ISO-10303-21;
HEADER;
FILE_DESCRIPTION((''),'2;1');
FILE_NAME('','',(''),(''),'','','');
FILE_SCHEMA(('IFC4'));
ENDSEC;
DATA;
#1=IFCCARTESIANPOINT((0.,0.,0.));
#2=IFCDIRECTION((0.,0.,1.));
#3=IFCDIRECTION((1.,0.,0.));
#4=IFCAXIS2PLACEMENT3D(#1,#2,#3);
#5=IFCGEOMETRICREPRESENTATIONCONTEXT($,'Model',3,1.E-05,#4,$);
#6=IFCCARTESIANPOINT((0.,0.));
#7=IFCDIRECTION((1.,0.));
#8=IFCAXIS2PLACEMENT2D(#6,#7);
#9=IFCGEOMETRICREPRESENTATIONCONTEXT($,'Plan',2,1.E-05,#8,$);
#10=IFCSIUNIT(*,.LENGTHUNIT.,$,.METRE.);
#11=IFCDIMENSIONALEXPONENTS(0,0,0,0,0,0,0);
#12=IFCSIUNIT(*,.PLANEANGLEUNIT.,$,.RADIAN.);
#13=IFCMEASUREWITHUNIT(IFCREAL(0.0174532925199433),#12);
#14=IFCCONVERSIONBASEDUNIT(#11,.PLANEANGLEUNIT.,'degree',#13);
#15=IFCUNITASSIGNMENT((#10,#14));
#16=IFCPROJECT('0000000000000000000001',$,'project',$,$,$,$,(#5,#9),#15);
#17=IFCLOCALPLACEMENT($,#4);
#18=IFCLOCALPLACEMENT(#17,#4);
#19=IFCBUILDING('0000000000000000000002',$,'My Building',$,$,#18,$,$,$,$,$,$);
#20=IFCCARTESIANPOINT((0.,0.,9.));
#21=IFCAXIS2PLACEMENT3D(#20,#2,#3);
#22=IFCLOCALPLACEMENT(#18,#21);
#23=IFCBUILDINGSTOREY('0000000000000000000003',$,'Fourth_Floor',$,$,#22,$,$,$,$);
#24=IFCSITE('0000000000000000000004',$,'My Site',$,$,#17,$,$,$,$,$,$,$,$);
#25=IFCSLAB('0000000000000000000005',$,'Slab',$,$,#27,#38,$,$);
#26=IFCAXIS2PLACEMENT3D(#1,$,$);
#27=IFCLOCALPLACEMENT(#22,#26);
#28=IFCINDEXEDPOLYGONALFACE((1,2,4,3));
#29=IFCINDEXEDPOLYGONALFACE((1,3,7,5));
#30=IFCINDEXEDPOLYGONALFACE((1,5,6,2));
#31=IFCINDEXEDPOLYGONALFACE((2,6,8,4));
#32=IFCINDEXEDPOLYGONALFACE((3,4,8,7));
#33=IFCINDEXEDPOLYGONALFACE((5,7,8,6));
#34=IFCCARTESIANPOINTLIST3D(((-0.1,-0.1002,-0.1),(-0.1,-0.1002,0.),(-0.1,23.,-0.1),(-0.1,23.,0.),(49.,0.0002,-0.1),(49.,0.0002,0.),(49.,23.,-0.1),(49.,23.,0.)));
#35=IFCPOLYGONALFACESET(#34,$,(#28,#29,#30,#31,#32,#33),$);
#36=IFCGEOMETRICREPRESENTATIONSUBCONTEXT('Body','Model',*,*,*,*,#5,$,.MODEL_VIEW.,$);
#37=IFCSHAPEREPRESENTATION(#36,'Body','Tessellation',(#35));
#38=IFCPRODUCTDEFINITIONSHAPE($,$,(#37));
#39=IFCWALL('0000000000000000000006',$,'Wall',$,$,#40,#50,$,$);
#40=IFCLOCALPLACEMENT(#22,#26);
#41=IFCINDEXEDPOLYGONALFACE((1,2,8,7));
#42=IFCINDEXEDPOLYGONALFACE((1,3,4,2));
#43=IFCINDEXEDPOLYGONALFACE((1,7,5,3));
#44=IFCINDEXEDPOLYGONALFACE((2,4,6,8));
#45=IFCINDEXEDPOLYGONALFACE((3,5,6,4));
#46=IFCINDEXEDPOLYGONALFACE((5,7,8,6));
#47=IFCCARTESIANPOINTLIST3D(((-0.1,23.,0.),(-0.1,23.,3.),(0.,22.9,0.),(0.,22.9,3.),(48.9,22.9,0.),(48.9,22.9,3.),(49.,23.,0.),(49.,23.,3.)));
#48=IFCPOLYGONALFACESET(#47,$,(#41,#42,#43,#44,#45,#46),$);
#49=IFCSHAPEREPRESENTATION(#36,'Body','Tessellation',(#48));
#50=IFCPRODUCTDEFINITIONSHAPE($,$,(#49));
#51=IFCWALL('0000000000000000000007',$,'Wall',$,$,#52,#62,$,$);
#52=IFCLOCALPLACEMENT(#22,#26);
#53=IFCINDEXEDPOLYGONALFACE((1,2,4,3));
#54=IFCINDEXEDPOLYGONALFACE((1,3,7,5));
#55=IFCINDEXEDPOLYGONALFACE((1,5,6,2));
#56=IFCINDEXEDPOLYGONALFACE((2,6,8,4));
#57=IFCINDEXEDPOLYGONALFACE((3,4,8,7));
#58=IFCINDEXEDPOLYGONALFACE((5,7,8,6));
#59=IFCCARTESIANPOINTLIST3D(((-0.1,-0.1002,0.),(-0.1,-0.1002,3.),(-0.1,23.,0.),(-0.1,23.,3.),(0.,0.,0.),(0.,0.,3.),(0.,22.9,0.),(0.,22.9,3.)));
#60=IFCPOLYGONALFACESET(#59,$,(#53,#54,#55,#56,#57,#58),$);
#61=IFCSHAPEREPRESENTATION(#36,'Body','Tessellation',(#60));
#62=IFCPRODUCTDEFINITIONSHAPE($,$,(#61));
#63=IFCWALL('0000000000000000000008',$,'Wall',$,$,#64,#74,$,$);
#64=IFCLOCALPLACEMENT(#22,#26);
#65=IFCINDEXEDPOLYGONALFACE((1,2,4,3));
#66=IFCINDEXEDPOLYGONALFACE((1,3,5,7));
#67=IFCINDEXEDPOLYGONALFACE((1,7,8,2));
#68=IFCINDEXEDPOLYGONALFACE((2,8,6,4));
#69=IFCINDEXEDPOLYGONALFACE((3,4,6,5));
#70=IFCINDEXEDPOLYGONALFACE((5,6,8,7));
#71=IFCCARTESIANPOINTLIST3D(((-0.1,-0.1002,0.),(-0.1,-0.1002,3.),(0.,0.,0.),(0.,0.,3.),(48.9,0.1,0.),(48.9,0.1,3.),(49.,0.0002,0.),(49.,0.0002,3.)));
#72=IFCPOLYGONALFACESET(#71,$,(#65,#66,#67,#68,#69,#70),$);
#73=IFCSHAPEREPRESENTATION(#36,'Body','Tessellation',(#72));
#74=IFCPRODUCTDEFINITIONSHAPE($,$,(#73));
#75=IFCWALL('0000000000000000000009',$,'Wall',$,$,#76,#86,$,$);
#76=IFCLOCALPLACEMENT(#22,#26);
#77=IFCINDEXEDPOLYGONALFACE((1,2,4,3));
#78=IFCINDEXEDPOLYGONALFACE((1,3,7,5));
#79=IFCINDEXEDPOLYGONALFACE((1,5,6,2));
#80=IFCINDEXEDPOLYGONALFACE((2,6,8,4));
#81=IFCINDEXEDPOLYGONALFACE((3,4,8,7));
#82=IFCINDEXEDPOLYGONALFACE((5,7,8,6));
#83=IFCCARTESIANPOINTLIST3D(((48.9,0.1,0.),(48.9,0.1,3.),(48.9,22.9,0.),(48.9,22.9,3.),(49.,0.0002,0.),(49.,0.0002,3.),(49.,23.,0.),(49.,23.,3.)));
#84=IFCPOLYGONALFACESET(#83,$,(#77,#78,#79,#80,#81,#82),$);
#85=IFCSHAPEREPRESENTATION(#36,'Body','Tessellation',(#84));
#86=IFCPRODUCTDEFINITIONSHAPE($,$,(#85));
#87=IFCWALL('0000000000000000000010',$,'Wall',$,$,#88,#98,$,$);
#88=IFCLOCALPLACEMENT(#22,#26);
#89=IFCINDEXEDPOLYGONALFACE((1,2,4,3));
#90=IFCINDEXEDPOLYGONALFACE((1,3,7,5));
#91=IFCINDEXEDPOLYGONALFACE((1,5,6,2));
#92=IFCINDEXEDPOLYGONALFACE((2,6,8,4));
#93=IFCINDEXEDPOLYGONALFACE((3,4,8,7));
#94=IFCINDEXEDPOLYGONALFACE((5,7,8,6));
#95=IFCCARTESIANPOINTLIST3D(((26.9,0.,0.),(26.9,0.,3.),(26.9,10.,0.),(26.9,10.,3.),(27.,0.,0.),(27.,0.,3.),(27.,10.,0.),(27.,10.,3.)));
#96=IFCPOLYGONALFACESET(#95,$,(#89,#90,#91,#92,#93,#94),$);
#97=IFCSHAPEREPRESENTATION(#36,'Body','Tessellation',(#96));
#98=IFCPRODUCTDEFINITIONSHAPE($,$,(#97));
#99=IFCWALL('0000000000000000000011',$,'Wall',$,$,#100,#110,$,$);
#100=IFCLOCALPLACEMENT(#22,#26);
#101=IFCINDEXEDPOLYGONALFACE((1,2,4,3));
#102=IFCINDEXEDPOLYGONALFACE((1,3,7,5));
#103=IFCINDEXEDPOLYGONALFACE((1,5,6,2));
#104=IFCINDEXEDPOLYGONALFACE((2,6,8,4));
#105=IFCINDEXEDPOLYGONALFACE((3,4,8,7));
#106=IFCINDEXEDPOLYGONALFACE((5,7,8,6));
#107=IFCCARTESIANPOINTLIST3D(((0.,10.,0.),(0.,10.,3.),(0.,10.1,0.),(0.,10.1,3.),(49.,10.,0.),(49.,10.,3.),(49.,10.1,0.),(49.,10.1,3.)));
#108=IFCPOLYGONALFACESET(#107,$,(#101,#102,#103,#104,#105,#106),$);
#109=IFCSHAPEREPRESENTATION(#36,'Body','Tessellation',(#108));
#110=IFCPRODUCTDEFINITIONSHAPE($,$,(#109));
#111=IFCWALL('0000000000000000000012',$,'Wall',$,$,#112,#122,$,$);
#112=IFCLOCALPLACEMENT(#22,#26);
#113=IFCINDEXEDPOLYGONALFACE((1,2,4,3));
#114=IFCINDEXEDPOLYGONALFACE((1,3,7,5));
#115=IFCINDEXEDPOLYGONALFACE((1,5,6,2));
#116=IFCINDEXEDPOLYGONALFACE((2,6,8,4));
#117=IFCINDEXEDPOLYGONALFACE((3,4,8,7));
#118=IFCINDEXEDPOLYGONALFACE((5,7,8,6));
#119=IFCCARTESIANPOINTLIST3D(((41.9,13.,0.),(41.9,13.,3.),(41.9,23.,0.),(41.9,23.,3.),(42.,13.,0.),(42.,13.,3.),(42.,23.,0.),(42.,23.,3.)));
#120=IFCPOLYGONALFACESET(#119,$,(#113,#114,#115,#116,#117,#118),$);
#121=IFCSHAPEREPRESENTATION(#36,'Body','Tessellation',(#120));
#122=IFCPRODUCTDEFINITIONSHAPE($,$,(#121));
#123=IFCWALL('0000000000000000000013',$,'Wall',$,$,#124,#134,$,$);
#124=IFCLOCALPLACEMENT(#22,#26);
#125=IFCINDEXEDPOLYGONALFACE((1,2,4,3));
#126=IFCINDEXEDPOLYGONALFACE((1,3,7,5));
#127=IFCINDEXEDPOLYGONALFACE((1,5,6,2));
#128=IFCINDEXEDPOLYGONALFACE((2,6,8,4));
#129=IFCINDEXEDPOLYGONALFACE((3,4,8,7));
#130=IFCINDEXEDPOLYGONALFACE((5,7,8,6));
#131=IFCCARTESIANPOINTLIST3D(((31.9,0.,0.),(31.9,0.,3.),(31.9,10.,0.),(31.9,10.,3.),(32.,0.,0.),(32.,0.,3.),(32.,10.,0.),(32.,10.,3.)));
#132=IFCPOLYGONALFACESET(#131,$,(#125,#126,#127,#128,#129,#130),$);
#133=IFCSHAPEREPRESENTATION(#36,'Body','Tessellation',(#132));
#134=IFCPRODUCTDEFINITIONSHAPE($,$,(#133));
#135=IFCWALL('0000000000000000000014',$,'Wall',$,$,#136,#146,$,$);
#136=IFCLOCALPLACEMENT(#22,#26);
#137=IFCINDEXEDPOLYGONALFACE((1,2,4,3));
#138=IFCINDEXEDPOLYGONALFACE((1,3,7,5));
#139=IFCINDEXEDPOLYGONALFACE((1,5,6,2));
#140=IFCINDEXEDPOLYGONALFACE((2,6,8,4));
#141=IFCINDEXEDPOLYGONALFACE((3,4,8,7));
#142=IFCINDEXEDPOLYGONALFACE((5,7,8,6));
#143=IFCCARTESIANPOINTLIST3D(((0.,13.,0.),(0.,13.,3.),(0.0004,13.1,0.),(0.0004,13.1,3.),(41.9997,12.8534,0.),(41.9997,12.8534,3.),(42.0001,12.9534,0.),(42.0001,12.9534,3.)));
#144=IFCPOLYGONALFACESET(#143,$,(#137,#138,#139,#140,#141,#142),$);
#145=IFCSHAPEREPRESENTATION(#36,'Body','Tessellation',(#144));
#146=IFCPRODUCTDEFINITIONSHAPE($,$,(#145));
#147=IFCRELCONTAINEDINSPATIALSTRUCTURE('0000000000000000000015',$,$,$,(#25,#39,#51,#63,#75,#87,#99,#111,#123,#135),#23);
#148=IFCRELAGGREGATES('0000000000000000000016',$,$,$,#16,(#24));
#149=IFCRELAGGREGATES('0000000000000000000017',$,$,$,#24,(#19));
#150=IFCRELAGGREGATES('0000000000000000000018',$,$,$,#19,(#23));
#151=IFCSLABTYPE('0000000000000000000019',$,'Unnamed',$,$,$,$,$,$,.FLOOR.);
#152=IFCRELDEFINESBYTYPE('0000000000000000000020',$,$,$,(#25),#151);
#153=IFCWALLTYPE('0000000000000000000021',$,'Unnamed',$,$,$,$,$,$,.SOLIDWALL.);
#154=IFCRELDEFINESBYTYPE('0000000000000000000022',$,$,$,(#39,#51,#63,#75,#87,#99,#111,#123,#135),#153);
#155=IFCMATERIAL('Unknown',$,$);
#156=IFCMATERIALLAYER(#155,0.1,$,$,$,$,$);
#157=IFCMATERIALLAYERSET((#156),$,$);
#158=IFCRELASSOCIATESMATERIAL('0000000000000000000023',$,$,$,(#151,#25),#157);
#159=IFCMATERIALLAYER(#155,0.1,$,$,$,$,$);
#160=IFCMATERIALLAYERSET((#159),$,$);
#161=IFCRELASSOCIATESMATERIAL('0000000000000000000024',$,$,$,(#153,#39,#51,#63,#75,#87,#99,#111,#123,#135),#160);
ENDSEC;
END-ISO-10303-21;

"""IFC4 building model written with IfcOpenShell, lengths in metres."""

from ifc_helpers import new_model, entity, si_unit, converted_unit, frame, origin_with_axes, origin_2d_with_axis, place, context, subcontext, project, spatial, line, indexed_curve, outline, extrude, material, layer, layer_set, layer_usage, type_object, element, save


model = new_model("IFC4")

# Units and contexts
model_context = context("Model", 3, precision=1e-05, world=origin_with_axes())
plan_context = context("Plan", 2, precision=1e-05, world=origin_2d_with_axis())
body_context = subcontext(model_context, "Body", "Model", "MODEL_VIEW")
ifc_project = project(units=[si_unit("LENGTHUNIT", "METRE"), converted_unit("PLANEANGLEUNIT", "degree", entity("IfcReal", 0.0174532925199433), si_unit("PLANEANGLEUNIT", "RADIAN"), dimensions=[0, 0, 0, 0, 0, 0, 0])], contexts=[model_context, plan_context])

# Site, building, storey
site_placement = place(None, origin_with_axes())
site = spatial("IfcSite", under=ifc_project, at=site_placement, Name="My Site")
building_placement = place(site_placement, origin_with_axes())
building = spatial("IfcBuilding", under=site, at=building_placement, Name="My Building")
storey_placement = place(building_placement, frame((0.0, 0.0, 9.0), z_axis=(0.0, 0.0, 1.0), x_axis=(1.0, 0.0, 0.0)))
storey = spatial("IfcBuildingStorey", under=building, at=storey_placement, Name="Fourth_Floor")

# Slab
ifc_material = material(Name="Unknown")
ifc_layer_1 = layer(ifc_material, 0.1)
ifc_layer_set_1 = layer_set([ifc_layer_1])
ifc_layer_usage_1 = layer_usage(ifc_layer_set_1, "AXIS3", "POSITIVE", -0.1)
slab_type = type_object("IfcSlabType", Name="Unnamed", PredefinedType="FLOOR", material=ifc_layer_set_1)
slab_placement = place(storey_placement, frame((-0.1, 23.0, 0.0), z_axis=(0.0, 0.0, 1.0), x_axis=(1.0, 0.0, 0.0)))
element("IfcSlab", 1, at=slab_placement, inside=storey, type_object=slab_type, material=ifc_layer_usage_1, Name="Slab", context=body_context, shape_type="SweptSolid", body=[
    extrude(outline(indexed_curve([(0.0, -23.1002), (49.1, -22.9998), (49.1, 0.0), (0.0, 0.0), (0.0, -23.1002)])), frame((0.0, 0.0, -0.1), z_axis=(0.0, 0.0, 1.0), x_axis=(1.0, 0.0, 0.0)), (0.0, 0.0, 1.0), 0.1),
])

# Walls
ifc_layer_2 = layer(ifc_material, 0.1)
ifc_layer_set_2 = layer_set([ifc_layer_2])
ifc_layer_usage_2 = layer_usage(ifc_layer_set_2, "AXIS2", "POSITIVE", 0.0)
wall_type = type_object("IfcWallType", Name="Unnamed", PredefinedType="SOLIDWALL", material=ifc_layer_set_2)
wall_1_placement = place(storey_placement, frame((0.0, 22.9, 0.0), z_axis=(0.0, 0.0, 1.0), x_axis=(1.0, 0.0, 0.0)))
element("IfcWall", 2, at=wall_1_placement, inside=storey, type_object=wall_type, material=ifc_layer_usage_2, Name="Wall", context=body_context, shape_type="SweptSolid", body=[
    extrude(outline(indexed_curve([(0.0, 0.0), (-0.1, 0.1), (49.0, 0.1), (48.9, 0.0)], segments=[line(1, 2, 3, 4, 1)])), origin_with_axes(), (0.0, 0.0, 1.0), 3.0),
])
ifc_layer_usage_3 = layer_usage(ifc_layer_set_2, "AXIS2", "POSITIVE", 0.0)
wall_2_placement = place(storey_placement, frame((0.0, 0.0, 0.0), z_axis=(0.0, 0.0, 1.0), x_axis=(0.0, 1.0, 0.0)))
element("IfcWall", 3, at=wall_2_placement, inside=storey, type_object=wall_type, material=ifc_layer_usage_3, Name="Wall", context=body_context, shape_type="SweptSolid", body=[
    extrude(outline(indexed_curve([(0.0, 0.0), (-0.1002, 0.1), (23.0, 0.1), (22.9, 0.0)], segments=[line(1, 2, 3, 4, 1)])), origin_with_axes(), (0.0, 0.0, 1.0), 3.0),
])
ifc_layer_usage_4 = layer_usage(ifc_layer_set_2, "AXIS2", "POSITIVE", 0.0)
wall_3_placement = place(storey_placement, frame((48.9, 0.1, 0.0), z_axis=(0.0, 0.0, 1.0), x_axis=(-0.999998, -0.002045, 0.0)))
element("IfcWall", 4, at=wall_3_placement, inside=storey, type_object=wall_type, material=ifc_layer_usage_4, Name="Wall", context=body_context, shape_type="SweptSolid", body=[
    extrude(outline(indexed_curve([(0.0, 0.0), (-0.0998, 0.1), (49.0003, 0.1), (48.9001, 0.0)], segments=[line(1, 2, 3, 4, 1)])), origin_with_axes(), (0.0, 0.0, 1.0), 3.0),
])
ifc_layer_usage_5 = layer_usage(ifc_layer_set_2, "AXIS2", "POSITIVE", 0.0)
wall_4_placement = place(storey_placement, frame((48.9, 22.9, 0.0), z_axis=(0.0, 0.0, 1.0), x_axis=(0.0, -1.0, 0.0)))
element("IfcWall", 5, at=wall_4_placement, inside=storey, type_object=wall_type, material=ifc_layer_usage_5, Name="Wall", context=body_context, shape_type="SweptSolid", body=[
    extrude(outline(indexed_curve([(0.0, 0.0), (-0.1, 0.1), (22.8998, 0.1), (22.8, 0.0)], segments=[line(1, 2, 3, 4, 1)])), origin_with_axes(), (0.0, 0.0, 1.0), 3.0),
])
ifc_layer_usage_6 = layer_usage(ifc_layer_set_2, "AXIS2", "POSITIVE", 0.0)
wall_5_placement = place(storey_placement, frame((26.9, 10.0, 0.0), z_axis=(0.0, 0.0, 1.0), x_axis=(0.0, -1.0, 0.0)))
element("IfcWall", 6, at=wall_5_placement, inside=storey, type_object=wall_type, material=ifc_layer_usage_6, Name="Wall", context=body_context, shape_type="SweptSolid", body=[
    extrude(outline(indexed_curve([(0.0, 0.0), (0.0, 0.1), (10.0, 0.1), (10.0, 0.0)], segments=[line(1, 2, 3, 4, 1)])), origin_with_axes(), (0.0, 0.0, 1.0), 3.0),
])
ifc_layer_usage_7 = layer_usage(ifc_layer_set_2, "AXIS2", "POSITIVE", 0.0)
wall_6_placement = place(storey_placement, frame((0.0, 10.0, 0.0), z_axis=(0.0, 0.0, 1.0), x_axis=(1.0, 0.0, 0.0)))
element("IfcWall", 7, at=wall_6_placement, inside=storey, type_object=wall_type, material=ifc_layer_usage_7, Name="Wall", context=body_context, shape_type="SweptSolid", body=[
    extrude(outline(indexed_curve([(0.0, 0.0), (0.0, 0.1), (49.0, 0.1), (49.0, 0.0)], segments=[line(1, 2, 3, 4, 1)])), origin_with_axes(), (0.0, 0.0, 1.0), 3.0),
])
ifc_layer_usage_8 = layer_usage(ifc_layer_set_2, "AXIS2", "POSITIVE", 0.0)
wall_7_placement = place(storey_placement, frame((41.9, 23.0, 0.0), z_axis=(0.0, 0.0, 1.0), x_axis=(0.0, -1.0, 0.0)))
element("IfcWall", 8, at=wall_7_placement, inside=storey, type_object=wall_type, material=ifc_layer_usage_8, Name="Wall", context=body_context, shape_type="SweptSolid", body=[
    extrude(outline(indexed_curve([(0.0, 0.0), (0.0, 0.1), (10.0, 0.1), (10.0, 0.0)], segments=[line(1, 2, 3, 4, 1)])), origin_with_axes(), (0.0, 0.0, 1.0), 3.0),
])
ifc_layer_usage_9 = layer_usage(ifc_layer_set_2, "AXIS2", "POSITIVE", 0.0)
wall_8_placement = place(storey_placement, frame((31.9, 10.0, 0.0), z_axis=(0.0, 0.0, 1.0), x_axis=(0.0, -1.0, 0.0)))
element("IfcWall", 9, at=wall_8_placement, inside=storey, type_object=wall_type, material=ifc_layer_usage_9, Name="Wall", context=body_context, shape_type="SweptSolid", body=[
    extrude(outline(indexed_curve([(0.0, 0.0), (0.0, 0.1), (10.0, 0.1), (10.0, 0.0)], segments=[line(1, 2, 3, 4, 1)])), origin_with_axes(), (0.0, 0.0, 1.0), 3.0),
])
ifc_layer_usage_10 = layer_usage(ifc_layer_set_2, "AXIS2", "POSITIVE", 0.0)
wall_9_placement = place(storey_placement, frame((0.0, 13.0, 0.0), z_axis=(0.0, 0.0, 1.0), x_axis=(0.999994, -0.003491, 0.0)))
element("IfcWall", 10, at=wall_9_placement, inside=storey, type_object=wall_type, material=ifc_layer_usage_10, Name="Wall", context=body_context, shape_type="SweptSolid", body=[
    extrude(outline(indexed_curve([(0.0, 0.0), (0.0, 0.1), (42.0, 0.1), (42.0, 0.0)], segments=[line(1, 2, 3, 4, 1)])), origin_with_axes(), (0.0, 0.0, 1.0), 3.0),
])

save(model, "model.ifc")
